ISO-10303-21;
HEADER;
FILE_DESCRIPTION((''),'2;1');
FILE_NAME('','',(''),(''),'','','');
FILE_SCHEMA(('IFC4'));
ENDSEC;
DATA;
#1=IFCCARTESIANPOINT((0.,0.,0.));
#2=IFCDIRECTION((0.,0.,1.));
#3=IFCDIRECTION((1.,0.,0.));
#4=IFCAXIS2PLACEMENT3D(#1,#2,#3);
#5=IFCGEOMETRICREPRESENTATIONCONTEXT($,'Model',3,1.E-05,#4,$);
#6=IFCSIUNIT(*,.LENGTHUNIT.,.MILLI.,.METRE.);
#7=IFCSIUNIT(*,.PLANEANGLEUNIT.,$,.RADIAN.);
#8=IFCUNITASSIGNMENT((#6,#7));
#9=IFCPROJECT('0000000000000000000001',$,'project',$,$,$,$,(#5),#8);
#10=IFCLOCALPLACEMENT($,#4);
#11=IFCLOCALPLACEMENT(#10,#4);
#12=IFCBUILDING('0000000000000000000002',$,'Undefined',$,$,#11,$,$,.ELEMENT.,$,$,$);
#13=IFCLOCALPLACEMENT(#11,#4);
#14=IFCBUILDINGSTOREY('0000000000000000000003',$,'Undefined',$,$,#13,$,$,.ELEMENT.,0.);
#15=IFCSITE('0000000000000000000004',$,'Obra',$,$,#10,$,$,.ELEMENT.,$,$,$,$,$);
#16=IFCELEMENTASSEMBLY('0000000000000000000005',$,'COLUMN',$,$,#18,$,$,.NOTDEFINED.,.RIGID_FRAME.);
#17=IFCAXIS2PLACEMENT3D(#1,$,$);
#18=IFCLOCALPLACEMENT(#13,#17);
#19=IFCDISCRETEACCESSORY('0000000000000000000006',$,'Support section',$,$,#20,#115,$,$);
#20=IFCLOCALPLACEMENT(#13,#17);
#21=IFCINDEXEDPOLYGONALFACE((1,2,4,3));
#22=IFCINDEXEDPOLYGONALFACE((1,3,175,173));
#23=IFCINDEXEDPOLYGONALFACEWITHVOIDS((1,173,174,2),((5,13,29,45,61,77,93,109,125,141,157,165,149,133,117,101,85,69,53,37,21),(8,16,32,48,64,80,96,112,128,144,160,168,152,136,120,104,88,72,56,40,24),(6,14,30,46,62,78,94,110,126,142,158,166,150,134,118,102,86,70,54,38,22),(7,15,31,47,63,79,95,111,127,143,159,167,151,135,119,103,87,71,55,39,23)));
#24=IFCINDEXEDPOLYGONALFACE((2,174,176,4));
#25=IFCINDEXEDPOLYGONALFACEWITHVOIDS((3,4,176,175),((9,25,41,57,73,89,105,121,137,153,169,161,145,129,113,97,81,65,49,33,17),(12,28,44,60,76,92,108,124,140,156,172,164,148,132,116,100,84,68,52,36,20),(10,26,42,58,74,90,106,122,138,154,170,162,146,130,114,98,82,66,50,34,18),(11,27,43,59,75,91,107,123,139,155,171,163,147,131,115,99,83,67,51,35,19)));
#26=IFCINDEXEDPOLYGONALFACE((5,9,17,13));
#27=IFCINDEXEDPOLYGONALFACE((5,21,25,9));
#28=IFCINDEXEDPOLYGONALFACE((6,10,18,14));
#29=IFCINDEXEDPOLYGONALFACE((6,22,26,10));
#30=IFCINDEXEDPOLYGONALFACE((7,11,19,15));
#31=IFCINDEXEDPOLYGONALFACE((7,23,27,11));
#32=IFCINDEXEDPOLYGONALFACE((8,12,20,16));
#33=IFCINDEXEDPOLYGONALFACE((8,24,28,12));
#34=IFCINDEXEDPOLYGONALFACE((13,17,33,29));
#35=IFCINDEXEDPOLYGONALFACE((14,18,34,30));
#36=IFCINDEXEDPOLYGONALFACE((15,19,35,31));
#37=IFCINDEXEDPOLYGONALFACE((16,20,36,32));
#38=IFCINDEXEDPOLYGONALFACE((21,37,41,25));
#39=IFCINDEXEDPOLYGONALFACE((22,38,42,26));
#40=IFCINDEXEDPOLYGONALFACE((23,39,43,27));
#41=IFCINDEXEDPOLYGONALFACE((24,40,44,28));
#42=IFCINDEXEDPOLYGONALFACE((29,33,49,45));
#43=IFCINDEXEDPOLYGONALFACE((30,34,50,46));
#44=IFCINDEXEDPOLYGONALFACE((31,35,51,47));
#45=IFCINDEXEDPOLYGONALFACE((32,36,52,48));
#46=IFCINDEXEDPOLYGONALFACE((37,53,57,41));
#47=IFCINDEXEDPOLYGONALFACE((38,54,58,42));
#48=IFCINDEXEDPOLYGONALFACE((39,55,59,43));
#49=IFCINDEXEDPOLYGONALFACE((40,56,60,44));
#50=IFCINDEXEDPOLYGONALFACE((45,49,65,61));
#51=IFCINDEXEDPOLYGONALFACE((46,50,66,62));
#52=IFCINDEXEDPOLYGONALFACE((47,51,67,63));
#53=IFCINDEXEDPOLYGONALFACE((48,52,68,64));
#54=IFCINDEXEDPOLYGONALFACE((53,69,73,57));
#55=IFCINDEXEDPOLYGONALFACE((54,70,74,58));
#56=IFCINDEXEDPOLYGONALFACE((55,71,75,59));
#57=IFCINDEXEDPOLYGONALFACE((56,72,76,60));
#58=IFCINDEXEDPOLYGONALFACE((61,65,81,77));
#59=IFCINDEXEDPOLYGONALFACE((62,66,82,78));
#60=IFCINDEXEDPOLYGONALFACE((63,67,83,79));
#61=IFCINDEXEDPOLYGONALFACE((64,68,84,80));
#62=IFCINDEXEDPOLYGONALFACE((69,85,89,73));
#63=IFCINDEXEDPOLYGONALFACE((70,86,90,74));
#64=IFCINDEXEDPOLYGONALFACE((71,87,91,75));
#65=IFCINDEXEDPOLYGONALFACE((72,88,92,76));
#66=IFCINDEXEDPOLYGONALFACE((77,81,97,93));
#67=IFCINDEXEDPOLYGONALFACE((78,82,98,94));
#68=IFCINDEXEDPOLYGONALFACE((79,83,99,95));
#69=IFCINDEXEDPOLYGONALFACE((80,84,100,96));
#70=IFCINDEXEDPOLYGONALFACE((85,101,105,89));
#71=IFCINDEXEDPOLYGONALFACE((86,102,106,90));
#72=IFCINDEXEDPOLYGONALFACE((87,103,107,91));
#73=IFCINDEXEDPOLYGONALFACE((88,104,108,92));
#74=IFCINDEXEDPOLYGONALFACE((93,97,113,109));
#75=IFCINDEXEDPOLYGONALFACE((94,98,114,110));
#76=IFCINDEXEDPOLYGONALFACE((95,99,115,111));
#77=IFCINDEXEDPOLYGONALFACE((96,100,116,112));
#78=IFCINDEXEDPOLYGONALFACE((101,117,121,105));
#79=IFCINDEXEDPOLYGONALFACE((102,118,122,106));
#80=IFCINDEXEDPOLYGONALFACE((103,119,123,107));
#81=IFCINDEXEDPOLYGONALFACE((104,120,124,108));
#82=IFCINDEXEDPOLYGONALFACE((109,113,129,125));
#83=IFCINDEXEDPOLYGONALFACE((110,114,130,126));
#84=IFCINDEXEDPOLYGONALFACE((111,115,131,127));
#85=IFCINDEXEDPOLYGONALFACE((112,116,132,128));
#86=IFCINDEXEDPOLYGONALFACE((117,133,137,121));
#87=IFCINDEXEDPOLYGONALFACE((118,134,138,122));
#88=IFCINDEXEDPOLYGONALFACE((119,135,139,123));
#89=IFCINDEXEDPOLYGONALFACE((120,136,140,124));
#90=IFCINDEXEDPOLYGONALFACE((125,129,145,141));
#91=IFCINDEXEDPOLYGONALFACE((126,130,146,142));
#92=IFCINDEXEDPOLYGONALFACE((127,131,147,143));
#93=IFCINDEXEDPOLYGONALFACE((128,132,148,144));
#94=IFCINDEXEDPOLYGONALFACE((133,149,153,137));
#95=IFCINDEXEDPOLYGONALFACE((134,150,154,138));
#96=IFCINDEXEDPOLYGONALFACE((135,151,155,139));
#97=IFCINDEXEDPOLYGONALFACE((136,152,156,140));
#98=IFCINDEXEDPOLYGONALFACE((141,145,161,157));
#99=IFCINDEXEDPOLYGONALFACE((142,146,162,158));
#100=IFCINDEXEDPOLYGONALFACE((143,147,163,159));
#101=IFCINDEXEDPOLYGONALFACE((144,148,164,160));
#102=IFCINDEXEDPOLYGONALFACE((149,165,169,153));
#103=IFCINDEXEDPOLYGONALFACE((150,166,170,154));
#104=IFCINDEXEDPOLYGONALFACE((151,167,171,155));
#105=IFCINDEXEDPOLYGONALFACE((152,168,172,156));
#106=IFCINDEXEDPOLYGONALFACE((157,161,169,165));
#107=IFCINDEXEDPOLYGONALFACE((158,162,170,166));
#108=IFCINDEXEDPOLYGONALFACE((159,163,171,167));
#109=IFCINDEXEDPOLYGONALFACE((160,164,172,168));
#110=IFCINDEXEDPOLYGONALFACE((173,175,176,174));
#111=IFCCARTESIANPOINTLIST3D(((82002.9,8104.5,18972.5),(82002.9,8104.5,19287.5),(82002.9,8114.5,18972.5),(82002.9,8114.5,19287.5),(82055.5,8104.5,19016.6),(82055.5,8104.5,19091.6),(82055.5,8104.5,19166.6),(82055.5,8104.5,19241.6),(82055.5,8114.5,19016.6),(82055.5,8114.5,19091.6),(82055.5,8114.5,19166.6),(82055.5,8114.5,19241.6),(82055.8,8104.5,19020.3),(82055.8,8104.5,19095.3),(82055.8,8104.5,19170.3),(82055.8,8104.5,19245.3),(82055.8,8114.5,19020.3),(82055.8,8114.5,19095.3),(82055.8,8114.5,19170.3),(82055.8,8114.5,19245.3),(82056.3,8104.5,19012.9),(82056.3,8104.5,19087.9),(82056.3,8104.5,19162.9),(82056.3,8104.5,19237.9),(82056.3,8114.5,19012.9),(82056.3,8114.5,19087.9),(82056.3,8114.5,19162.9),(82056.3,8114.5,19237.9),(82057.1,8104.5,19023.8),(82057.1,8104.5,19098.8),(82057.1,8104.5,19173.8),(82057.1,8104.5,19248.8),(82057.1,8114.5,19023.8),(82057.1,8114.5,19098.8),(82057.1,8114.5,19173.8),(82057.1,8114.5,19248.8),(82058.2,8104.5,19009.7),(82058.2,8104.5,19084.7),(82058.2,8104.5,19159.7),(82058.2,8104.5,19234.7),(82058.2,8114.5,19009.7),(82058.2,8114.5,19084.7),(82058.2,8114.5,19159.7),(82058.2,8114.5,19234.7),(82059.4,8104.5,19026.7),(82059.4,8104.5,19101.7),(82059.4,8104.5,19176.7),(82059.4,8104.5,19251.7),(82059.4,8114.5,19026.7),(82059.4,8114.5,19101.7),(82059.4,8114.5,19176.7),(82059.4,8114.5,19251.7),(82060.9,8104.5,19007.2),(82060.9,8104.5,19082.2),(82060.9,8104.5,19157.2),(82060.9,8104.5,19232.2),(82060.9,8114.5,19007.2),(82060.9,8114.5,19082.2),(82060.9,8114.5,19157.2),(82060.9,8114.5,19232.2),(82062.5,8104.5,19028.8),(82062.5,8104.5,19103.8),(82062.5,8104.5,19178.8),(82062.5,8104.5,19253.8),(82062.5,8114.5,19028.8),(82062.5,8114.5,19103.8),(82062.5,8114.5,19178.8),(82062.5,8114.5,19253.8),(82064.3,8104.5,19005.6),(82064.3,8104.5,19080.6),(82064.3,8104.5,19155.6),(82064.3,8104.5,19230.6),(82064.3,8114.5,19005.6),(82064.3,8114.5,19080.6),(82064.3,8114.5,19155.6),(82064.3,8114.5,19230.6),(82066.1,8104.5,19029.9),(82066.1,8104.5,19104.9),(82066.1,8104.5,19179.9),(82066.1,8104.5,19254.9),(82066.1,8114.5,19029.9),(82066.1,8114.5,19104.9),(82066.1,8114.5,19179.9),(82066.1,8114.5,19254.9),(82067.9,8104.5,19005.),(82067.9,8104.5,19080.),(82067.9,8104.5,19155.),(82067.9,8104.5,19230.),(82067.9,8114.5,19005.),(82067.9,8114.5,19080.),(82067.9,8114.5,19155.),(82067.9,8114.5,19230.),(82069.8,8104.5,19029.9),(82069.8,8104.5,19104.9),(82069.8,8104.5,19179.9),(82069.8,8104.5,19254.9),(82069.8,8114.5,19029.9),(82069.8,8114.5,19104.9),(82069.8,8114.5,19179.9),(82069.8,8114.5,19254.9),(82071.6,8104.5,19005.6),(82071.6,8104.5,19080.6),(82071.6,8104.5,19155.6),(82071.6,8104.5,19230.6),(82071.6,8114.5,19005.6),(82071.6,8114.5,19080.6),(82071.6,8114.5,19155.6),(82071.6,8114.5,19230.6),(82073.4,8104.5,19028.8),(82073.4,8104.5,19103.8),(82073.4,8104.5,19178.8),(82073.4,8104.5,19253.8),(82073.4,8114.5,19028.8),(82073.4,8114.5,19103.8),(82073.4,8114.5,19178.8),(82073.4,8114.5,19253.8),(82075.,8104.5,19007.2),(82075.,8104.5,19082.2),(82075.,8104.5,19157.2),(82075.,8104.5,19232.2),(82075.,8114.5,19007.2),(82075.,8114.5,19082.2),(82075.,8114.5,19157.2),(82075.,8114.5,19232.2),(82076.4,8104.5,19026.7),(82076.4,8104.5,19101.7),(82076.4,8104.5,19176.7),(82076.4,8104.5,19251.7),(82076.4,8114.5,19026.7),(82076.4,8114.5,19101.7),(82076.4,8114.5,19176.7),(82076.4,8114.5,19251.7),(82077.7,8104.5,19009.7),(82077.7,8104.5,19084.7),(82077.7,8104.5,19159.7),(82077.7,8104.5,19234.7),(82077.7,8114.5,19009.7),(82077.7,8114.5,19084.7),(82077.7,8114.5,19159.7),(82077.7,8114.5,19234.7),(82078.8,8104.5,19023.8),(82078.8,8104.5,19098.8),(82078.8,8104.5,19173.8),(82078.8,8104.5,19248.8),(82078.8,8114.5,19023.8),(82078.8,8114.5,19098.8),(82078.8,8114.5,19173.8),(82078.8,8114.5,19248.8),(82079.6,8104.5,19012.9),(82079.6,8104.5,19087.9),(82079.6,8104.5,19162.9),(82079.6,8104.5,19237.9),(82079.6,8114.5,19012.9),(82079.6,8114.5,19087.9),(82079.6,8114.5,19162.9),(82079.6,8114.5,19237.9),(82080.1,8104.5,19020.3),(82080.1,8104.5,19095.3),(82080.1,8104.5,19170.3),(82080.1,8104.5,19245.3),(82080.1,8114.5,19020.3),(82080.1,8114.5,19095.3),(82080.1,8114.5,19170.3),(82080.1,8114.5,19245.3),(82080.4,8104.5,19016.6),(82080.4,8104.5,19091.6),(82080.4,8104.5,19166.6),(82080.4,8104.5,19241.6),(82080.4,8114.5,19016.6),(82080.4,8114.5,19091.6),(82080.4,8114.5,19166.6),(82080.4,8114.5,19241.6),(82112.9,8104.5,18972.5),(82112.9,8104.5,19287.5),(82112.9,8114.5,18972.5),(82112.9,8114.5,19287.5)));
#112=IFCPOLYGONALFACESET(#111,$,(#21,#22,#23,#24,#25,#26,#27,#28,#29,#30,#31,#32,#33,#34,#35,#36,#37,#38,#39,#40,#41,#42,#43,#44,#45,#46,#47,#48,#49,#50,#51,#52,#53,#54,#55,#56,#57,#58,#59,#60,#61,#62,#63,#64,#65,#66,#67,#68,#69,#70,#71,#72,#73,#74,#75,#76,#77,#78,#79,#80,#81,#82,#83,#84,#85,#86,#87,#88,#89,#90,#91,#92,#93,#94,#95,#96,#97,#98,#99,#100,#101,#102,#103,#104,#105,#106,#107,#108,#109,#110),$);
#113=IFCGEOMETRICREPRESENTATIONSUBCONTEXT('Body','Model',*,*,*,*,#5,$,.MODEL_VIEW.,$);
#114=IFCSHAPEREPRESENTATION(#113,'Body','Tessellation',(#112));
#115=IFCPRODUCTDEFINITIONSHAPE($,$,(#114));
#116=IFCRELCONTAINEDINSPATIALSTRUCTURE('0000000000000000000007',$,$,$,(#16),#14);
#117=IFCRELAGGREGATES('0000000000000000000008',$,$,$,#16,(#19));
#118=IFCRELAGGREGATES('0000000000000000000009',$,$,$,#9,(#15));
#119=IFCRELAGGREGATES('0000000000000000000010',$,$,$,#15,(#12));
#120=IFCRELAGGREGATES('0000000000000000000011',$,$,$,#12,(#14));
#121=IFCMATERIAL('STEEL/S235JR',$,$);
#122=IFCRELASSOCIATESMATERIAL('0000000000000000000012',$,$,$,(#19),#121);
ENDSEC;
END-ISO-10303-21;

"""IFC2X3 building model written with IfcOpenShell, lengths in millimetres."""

from ifc_helpers import new_model, si_unit, frame, origin_with_axes, origin_2d_with_axis, place, context, subcontext, project, spatial, rectangle, circle, extrude, source, transform, mapped, material, element, aggregate, save


model = new_model("IFC2X3")

# Units and contexts
model_context = context("Model", 3, precision=1e-05, world=origin_with_axes())
body_context = subcontext(model_context, "Body", "Model", "MODEL_VIEW")
ifc_project = project(units=[si_unit("LENGTHUNIT", "METRE", prefix="MILLI"), si_unit("PLANEANGLEUNIT", "RADIAN")], contexts=[model_context])

# Site, building, storey
site_placement = place(None, origin_with_axes())
site = spatial("IfcSite", under=ifc_project, at=site_placement, Name="Obra", CompositionType="ELEMENT")
building_placement = place(site_placement, origin_with_axes())
building = spatial("IfcBuilding", under=site, at=building_placement, Name="Undefined", CompositionType="ELEMENT")
storey_placement = place(building_placement, origin_with_axes())
storey = spatial("IfcBuildingStorey", under=building, at=storey_placement, Name="Undefined", CompositionType="ELEMENT", Elevation=0.0)

# Element assembly
assembly_1_placement = place(storey_placement, origin_with_axes())
assembly_1 = element("IfcElementAssembly", 1, at=assembly_1_placement, inside=storey, Name="COLUMN", AssemblyPlace="NOTDEFINED", PredefinedType="RIGID_FRAME")
ifc_material_1 = material(Name="STEEL/S235JR")

# Discrete accessory, opening
discrete_accessory_1_placement = place(assembly_1_placement, frame((82057.9, 8109.5, 18972.5), z_axis=(0.0, 0.0, 1.0), x_axis=(-1.0, 0.0, 0.0)))
discrete_accessory_1 = element("IfcDiscreteAccessory", 2, at=discrete_accessory_1_placement, material=ifc_material_1, Name="Support section", context=body_context, shape_type="SweptSolid", body=[
    extrude(rectangle(XDim=10.0, YDim=110.0, at=origin_2d_with_axis()), frame((0.0, 0.0, 315.0), z_axis=(0.0, 0.0, -1.0), x_axis=(0.0, 1.0, 0.0)), (0.0, 0.0, 1.0), 315.0),
])
shared_shape_1 = source(origin_with_axes(), body_context, "Body", "SweptSolid", [
    extrude(circle(Radius=12.5, at=origin_2d_with_axis()), frame((0.0, -15.8, 0.0), z_axis=(0.0, 1.0, 0.0), x_axis=(1.0, 0.0, 0.0)), (0.0, 0.0, 1.0), 10.2),
])
opening_1_placement = place(assembly_1_placement, frame((82022.9, 8120.2, 19350.0), z_axis=(1.0, 0.0, 0.0), x_axis=(0.0, 0.0, -1.0)))
element("IfcOpeningElement", 3, at=opening_1_placement, cuts=discrete_accessory_1, ObjectType="Opening", context=body_context, shape_type="MappedRepresentation", body=[
    mapped(shared_shape_1, transform((107.5, 0.0, 45.0))),
    mapped(shared_shape_1, transform((182.5, 0.0, 45.0))),
    mapped(shared_shape_1, transform((257.5, 0.0, 45.0))),
    mapped(shared_shape_1, transform((332.5, 0.0, 45.0))),
])

aggregate(assembly_1, [discrete_accessory_1])

save(model, "model.ifc")
